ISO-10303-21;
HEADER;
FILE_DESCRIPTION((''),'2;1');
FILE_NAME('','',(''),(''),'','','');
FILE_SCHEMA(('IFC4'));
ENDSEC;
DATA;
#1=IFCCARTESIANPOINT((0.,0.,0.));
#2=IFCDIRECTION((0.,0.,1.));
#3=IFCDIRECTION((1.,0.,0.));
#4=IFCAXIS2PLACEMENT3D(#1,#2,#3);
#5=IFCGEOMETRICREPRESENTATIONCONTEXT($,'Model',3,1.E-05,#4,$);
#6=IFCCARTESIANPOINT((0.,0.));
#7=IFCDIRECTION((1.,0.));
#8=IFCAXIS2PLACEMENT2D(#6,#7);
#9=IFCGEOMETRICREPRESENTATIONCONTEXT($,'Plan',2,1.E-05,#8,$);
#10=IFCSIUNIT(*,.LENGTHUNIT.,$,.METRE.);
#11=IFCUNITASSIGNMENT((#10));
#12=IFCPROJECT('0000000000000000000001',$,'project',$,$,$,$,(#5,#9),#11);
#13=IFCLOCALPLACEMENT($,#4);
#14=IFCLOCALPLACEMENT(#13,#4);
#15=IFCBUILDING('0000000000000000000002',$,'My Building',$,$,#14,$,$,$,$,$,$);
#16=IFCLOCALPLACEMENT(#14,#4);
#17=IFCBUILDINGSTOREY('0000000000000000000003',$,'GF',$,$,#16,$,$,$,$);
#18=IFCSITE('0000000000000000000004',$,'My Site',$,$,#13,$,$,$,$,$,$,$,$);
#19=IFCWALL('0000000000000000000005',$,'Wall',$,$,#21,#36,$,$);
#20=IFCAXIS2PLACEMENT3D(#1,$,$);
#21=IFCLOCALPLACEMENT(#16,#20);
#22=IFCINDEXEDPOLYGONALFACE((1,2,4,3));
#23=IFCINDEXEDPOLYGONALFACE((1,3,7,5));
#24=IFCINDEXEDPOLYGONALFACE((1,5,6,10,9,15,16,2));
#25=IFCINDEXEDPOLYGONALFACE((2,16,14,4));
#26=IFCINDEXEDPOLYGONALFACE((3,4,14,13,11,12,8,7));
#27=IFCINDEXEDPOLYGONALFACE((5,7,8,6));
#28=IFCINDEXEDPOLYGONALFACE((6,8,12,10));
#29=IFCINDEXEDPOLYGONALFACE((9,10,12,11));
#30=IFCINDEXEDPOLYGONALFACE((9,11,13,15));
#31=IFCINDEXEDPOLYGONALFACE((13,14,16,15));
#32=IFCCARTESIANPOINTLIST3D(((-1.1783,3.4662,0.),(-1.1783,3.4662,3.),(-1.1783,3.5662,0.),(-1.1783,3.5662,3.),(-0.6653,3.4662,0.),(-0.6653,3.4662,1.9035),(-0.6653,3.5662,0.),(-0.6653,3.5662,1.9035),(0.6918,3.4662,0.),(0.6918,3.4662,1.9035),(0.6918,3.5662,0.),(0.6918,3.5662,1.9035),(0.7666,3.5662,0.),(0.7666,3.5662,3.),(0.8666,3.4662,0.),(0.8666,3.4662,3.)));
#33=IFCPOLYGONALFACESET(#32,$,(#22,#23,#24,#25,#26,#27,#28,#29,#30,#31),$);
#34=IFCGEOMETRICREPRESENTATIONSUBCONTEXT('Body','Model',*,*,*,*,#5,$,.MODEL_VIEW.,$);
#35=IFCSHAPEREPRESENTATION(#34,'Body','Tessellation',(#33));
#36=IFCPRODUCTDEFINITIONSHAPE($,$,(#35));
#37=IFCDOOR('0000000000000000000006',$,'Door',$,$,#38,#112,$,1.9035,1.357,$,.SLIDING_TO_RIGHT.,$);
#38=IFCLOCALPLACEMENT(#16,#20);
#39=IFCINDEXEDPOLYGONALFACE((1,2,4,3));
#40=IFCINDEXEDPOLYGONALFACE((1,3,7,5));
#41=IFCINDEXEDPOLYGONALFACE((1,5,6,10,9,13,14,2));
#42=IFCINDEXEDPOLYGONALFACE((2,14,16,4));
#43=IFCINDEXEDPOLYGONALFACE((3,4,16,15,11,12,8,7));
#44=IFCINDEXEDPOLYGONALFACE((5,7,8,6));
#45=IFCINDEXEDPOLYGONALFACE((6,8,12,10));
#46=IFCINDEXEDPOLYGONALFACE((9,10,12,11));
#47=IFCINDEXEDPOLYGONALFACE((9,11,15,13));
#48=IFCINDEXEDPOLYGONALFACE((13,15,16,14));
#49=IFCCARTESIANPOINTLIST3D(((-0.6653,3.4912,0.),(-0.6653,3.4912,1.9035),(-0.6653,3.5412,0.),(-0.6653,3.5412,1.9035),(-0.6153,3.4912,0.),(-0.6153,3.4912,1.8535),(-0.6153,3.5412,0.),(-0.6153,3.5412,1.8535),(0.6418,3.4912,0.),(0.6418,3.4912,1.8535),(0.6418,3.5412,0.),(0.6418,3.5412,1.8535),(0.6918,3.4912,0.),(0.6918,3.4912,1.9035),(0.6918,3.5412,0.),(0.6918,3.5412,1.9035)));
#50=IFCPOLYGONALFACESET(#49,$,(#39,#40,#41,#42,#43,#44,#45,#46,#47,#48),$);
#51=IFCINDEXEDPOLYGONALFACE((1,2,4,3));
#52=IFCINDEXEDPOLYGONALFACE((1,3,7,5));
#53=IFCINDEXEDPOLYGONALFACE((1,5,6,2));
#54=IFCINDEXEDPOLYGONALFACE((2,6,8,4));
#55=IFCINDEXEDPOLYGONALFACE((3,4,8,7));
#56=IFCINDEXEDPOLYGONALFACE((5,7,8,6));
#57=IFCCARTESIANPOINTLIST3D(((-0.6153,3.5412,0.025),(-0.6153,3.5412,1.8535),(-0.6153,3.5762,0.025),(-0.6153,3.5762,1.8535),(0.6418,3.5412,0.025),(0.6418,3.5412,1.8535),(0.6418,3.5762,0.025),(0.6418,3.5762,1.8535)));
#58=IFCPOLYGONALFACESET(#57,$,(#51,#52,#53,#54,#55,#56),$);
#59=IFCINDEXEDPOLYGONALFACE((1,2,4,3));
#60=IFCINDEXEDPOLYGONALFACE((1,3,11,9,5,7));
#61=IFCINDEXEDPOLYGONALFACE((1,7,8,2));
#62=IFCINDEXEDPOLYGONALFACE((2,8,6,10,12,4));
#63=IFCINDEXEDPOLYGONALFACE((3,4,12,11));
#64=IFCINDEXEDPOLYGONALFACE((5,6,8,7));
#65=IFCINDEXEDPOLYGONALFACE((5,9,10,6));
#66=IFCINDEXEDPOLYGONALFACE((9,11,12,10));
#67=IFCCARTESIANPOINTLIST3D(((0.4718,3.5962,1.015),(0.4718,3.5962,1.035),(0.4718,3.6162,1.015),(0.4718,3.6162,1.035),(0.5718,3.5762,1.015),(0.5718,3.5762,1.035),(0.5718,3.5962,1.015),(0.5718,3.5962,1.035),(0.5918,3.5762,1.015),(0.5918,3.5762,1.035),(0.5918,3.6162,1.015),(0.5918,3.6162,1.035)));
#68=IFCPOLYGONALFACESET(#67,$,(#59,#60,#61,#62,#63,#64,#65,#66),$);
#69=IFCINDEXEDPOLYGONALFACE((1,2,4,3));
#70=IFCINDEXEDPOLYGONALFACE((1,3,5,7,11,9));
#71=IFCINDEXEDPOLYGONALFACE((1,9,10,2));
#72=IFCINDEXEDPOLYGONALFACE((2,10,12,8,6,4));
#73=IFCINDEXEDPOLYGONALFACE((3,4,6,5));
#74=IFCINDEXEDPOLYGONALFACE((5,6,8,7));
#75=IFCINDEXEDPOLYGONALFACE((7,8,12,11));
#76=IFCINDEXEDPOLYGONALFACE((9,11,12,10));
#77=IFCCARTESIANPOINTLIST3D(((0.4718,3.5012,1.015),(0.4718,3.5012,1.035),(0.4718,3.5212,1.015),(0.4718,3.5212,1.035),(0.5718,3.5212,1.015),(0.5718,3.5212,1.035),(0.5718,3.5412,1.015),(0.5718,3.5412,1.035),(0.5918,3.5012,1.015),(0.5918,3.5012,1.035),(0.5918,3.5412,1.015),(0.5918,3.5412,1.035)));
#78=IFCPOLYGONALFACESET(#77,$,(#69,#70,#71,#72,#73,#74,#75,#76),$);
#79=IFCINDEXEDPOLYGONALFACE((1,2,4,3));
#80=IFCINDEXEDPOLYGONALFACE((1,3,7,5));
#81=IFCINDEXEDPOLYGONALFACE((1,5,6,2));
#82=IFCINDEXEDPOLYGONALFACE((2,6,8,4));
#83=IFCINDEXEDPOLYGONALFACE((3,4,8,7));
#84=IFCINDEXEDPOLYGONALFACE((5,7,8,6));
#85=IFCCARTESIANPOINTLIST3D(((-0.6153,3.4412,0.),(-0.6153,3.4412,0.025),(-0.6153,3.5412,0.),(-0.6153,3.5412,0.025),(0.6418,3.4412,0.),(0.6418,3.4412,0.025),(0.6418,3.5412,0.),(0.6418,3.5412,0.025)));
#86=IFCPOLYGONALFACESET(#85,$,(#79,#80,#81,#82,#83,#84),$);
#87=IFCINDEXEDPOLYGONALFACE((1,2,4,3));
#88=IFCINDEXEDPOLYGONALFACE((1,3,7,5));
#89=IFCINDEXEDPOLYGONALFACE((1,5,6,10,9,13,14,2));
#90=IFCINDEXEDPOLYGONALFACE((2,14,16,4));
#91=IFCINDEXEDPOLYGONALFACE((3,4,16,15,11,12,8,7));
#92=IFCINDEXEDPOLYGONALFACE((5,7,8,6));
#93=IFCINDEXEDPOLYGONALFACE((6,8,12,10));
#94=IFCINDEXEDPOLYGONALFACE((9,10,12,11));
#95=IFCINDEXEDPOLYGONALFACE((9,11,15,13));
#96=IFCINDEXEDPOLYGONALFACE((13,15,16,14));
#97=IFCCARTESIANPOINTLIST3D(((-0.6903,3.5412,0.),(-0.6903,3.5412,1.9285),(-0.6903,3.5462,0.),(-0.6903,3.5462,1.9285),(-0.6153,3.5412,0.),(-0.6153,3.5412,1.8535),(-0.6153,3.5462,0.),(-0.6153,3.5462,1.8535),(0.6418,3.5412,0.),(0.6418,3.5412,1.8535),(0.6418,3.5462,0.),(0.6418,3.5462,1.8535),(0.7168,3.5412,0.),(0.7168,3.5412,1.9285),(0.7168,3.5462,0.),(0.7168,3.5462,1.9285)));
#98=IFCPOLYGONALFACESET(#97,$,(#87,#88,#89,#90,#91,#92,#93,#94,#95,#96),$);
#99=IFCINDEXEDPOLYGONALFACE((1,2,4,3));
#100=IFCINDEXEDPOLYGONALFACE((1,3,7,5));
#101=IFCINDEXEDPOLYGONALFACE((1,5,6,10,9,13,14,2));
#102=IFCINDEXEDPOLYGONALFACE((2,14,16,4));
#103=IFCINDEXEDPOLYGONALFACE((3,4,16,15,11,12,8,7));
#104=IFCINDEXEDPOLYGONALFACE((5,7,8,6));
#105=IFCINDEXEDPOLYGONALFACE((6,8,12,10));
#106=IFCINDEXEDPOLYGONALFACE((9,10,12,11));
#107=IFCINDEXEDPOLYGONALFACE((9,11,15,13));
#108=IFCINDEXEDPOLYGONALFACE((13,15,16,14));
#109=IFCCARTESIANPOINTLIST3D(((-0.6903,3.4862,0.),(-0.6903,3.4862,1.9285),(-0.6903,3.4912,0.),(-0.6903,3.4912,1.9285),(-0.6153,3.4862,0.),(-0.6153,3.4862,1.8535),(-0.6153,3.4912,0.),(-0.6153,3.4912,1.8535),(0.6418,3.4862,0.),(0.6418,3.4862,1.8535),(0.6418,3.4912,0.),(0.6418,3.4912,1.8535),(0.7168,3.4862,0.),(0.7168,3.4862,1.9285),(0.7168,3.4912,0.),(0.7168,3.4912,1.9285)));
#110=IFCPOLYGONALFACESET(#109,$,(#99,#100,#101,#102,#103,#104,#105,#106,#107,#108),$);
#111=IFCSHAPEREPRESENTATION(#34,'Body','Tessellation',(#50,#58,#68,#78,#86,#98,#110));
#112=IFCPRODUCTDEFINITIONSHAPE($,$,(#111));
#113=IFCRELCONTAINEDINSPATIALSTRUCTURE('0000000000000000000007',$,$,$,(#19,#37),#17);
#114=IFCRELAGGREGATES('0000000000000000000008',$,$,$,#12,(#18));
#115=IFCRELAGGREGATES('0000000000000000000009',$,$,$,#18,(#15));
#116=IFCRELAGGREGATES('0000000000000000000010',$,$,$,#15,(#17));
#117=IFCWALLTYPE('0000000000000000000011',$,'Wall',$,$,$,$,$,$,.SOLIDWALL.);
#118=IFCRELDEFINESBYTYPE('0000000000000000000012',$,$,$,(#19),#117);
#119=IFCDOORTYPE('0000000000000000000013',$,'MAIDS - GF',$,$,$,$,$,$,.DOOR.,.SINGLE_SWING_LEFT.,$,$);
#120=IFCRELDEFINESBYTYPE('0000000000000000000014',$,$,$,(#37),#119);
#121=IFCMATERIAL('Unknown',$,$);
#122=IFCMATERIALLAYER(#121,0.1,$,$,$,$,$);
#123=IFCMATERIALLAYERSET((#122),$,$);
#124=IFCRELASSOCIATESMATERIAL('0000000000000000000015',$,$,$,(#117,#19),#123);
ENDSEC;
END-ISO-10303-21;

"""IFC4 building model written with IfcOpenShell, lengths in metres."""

from ifc_helpers import new_model, entity, si_unit, frame, origin_with_axes, origin_2d_with_axis, place, context, subcontext, project, spatial, line, indexed_curve, outline, extrude, shape, source, transform, mapped, material, layer, layer_set, layer_usage, type_object, type_shapes, element, fill, save


model = new_model("IFC4")

# Units and contexts
model_context = context("Model", 3, precision=1e-05, world=origin_with_axes())
plan_context = context("Plan", 2, precision=1e-05, world=origin_2d_with_axis())
body_context_1 = subcontext(model_context, "Body", "Model", "MODEL_VIEW")
body_context_2 = subcontext(plan_context, "Body", "Plan", "PLAN_VIEW")
ifc_project = project(units=[si_unit("LENGTHUNIT", "METRE")], contexts=[model_context, plan_context])

# Site, building, storey
site_placement = place(None, origin_with_axes())
site = spatial("IfcSite", under=ifc_project, at=site_placement, Name="My Site")
building_placement = place(site_placement, origin_with_axes())
building = spatial("IfcBuilding", under=site, at=building_placement, Name="My Building")
storey_placement = place(building_placement, origin_with_axes())
storey = spatial("IfcBuildingStorey", under=building, at=storey_placement, Name="GF")

# Shared definitions
ifc_material = material(Name="Unknown")

# Shared definitions
ifc_layer_1 = layer(ifc_material, 0.1)
ifc_layer_set_1 = layer_set([ifc_layer_1])
wall_type = type_object("IfcWallType", Name="Wall", PredefinedType="SOLIDWALL", material=ifc_layer_set_1)

# Wall, opening, door
ifc_layer_usage_1 = layer_usage(ifc_layer_set_1, "AXIS2", "POSITIVE", 0.0)
wall_1_placement = place(storey_placement, frame((0.7666, 3.5662, 0.0), z_axis=(0.0, 0.0, 1.0), x_axis=(-1.0, 0.0, 0.0)))
wall_1 = element("IfcWall", 1, at=wall_1_placement, inside=storey, type_object=wall_type, material=ifc_layer_usage_1, Name="Wall", context=body_context_1, shape_type="SweptSolid", body=[
    extrude(outline(indexed_curve([(0.0, 0.0), (-0.1, 0.1), (1.9449, 0.1), (1.9449, 0.0)], segments=[line(1, 2, 3, 4, 1)])), origin_with_axes(), (0.0, 0.0, 1.0), 3.0),
])
shared_shape_1 = source(origin_with_axes(), body_context_1, "Body", "SweptSolid", [
    extrude(outline(indexed_curve([(0.0, 0.0), (1.357, 0.0), (1.357, 1.9035), (0.0, 1.9035)], segments=[line(1, 2, 3, 4, 1)])), frame((0.0, -0.6, 0.0), z_axis=(0.0, -1.0, 0.0), x_axis=(1.0, 0.0, 0.0)), (0.0, 0.0, -1.0), 1.2),
])
opening_1_placement = place(wall_1_placement, frame((0.0748, 0.025, 0.0), z_axis=(0.0, 0.0, 1.0), x_axis=(1.0, -0.000001, 0.0)))
opening_1 = element("IfcOpeningElement", 2, at=opening_1_placement, cuts=wall_1, PredefinedType="OPENING", context=body_context_1, shape_type="MappedRepresentation", body=[
    mapped(shared_shape_1, transform((0.0, 0.0, 0.0), x_axis=(1.0, 0.0, 0.0), y_axis=(0.0, 1.0, 0.0), z_axis=(0.0, 0.0, 1.0), scale=1.0)),
])
door_type_1 = type_object("IfcDoorType", Name="MAIDS - GF", OperationType="SINGLE_SWING_LEFT", PredefinedType="DOOR")
shared_shape_2 = source(origin_with_axes(), body_context_1, "Body", "SweptSolid", [
    extrude(outline(indexed_curve([(0.0, 0.0), (0.0, 1.9035), (1.357, 1.9035), (1.357, 0.0), (1.307, 0.0), (1.307, 1.8535), (0.05, 1.8535), (0.05, 0.0)], segments=[line(1, 2, 3, 4, 5, 6, 7, 8, 1)])), frame((0.0, 0.0, 0.0), z_axis=(0.0, -1.0, 0.0), x_axis=(1.0, 0.0, 0.0)), (0.0, 0.0, -1.0), 0.05),
    extrude(outline(indexed_curve([(0.0, 0.0), (1.257, 0.0), (1.257, 0.035), (0.0, 0.035)], segments=[line(1, 2, 3, 4, 1)])), frame((0.05, -0.035, 0.025), z_axis=(0.0, 0.0, 1.0), x_axis=(1.0, 0.0, 0.0)), (0.0, 0.0, 1.0), 1.8285),
    extrude(outline(indexed_curve([(0.0, 0.0), (0.0, -0.04), (0.12, -0.04), (0.12, -0.02), (0.02, -0.02), (0.02, 0.0)], segments=[line(1, 2, 3, 4, 5, 6, 1)])), frame((0.1, -0.035, 1.015), z_axis=(0.0, 0.0, 1.0), x_axis=(1.0, 0.0, 0.0)), (0.0, 0.0, 1.0), 0.02),
    extrude(outline(indexed_curve([(0.0, 0.0), (0.0, 0.04), (0.12, 0.04), (0.12, 0.02), (0.02, 0.02), (0.02, 0.0)], segments=[line(1, 2, 3, 4, 5, 6, 1)])), frame((0.1, 0.0, 1.015), z_axis=(0.0, 0.0, 1.0), x_axis=(1.0, 0.0, 0.0)), (0.0, 0.0, 1.0), 0.02),
    extrude(outline(indexed_curve([(0.0, 0.0), (1.257, 0.0), (1.257, 0.1), (0.0, 0.1)], segments=[line(1, 2, 3, 4, 1)])), frame((0.05, 0.0, 0.0), z_axis=(0.0, 0.0, 1.0), x_axis=(1.0, 0.0, 0.0)), (0.0, 0.0, 1.0), 0.025),
    extrude(outline(indexed_curve([(0.0, 0.0), (0.0, 1.9285), (1.407, 1.9285), (1.407, 0.0), (1.332, 0.0), (1.332, 1.8535), (0.075, 1.8535), (0.075, 0.0)], segments=[line(1, 2, 3, 4, 5, 6, 7, 8, 1)])), frame((-0.025, -0.005, 0.0), z_axis=(0.0, -1.0, 0.0), x_axis=(1.0, 0.0, 0.0)), (0.0, 0.0, -1.0), 0.005),
    extrude(outline(indexed_curve([(0.0, 0.0), (0.0, 1.9285), (1.407, 1.9285), (1.407, 0.0), (1.332, 0.0), (1.332, 1.8535), (0.075, 1.8535), (0.075, 0.0)], segments=[line(1, 2, 3, 4, 5, 6, 7, 8, 1)])), frame((-0.025, 0.05, 0.0), z_axis=(0.0, -1.0, 0.0), x_axis=(1.0, 0.0, 0.0)), (0.0, 0.0, -1.0), 0.005),
])
shared_shape_3 = source(origin_with_axes(), body_context_2, "Body", "Curve2D", [
    entity("IfcIndexedPolyCurve", entity("IfcCartesianPointList2D", [[0.0, 0.0], [0.05, 0.0], [0.05, 0.05], [0.0, 0.05]]), [entity("IfcLineIndex", [1, 2, 3, 4, 1])]),
    entity("IfcIndexedPolyCurve", entity("IfcCartesianPointList2D", [[1.357, 0.0], [1.307, 0.0], [1.307, 0.05], [1.357, 0.05]]), [entity("IfcLineIndex", [1, 2, 3, 4, 1])]),
    entity("IfcIndexedPolyCurve", entity("IfcCartesianPointList2D", [[1.9356, -0.035], [0.6785, -0.035], [0.6785, 0.0], [1.9356, 0.0]]), [entity("IfcLineIndex", [1, 2, 3, 4, 1])]),
])
type_shapes(door_type_1, [shared_shape_2, shared_shape_3])
door_1_placement = place(opening_1_placement, frame((0.0, 0.0, 0.0), z_axis=(0.0, 0.0, 1.0), x_axis=(1.0, 0.0, 0.0)))
door_1 = element("IfcDoor", 3, at=door_1_placement, inside=storey, type_object=door_type_1, Name="Door", OperationType="SLIDING_TO_RIGHT", OverallHeight=1.9035, OverallWidth=1.357, shapes=[
    shape(body_context_1, "Body", "MappedRepresentation", [mapped(shared_shape_2, transform((0.0, 0.0, 0.0), x_axis=(1.0, 0.0, 0.0), y_axis=(0.0, 1.0, 0.0), z_axis=(0.0, 0.0, 1.0), scale=1.0))]),
    shape(body_context_2, "Body", "MappedRepresentation", [mapped(shared_shape_3, transform((0.0, 0.0, 0.0), x_axis=(1.0, 0.0, 0.0), y_axis=(0.0, 1.0, 0.0), z_axis=(0.0, 0.0, 1.0), scale=1.0))]),
])
fill(opening_1, door_1)

save(model, "model.ifc")
